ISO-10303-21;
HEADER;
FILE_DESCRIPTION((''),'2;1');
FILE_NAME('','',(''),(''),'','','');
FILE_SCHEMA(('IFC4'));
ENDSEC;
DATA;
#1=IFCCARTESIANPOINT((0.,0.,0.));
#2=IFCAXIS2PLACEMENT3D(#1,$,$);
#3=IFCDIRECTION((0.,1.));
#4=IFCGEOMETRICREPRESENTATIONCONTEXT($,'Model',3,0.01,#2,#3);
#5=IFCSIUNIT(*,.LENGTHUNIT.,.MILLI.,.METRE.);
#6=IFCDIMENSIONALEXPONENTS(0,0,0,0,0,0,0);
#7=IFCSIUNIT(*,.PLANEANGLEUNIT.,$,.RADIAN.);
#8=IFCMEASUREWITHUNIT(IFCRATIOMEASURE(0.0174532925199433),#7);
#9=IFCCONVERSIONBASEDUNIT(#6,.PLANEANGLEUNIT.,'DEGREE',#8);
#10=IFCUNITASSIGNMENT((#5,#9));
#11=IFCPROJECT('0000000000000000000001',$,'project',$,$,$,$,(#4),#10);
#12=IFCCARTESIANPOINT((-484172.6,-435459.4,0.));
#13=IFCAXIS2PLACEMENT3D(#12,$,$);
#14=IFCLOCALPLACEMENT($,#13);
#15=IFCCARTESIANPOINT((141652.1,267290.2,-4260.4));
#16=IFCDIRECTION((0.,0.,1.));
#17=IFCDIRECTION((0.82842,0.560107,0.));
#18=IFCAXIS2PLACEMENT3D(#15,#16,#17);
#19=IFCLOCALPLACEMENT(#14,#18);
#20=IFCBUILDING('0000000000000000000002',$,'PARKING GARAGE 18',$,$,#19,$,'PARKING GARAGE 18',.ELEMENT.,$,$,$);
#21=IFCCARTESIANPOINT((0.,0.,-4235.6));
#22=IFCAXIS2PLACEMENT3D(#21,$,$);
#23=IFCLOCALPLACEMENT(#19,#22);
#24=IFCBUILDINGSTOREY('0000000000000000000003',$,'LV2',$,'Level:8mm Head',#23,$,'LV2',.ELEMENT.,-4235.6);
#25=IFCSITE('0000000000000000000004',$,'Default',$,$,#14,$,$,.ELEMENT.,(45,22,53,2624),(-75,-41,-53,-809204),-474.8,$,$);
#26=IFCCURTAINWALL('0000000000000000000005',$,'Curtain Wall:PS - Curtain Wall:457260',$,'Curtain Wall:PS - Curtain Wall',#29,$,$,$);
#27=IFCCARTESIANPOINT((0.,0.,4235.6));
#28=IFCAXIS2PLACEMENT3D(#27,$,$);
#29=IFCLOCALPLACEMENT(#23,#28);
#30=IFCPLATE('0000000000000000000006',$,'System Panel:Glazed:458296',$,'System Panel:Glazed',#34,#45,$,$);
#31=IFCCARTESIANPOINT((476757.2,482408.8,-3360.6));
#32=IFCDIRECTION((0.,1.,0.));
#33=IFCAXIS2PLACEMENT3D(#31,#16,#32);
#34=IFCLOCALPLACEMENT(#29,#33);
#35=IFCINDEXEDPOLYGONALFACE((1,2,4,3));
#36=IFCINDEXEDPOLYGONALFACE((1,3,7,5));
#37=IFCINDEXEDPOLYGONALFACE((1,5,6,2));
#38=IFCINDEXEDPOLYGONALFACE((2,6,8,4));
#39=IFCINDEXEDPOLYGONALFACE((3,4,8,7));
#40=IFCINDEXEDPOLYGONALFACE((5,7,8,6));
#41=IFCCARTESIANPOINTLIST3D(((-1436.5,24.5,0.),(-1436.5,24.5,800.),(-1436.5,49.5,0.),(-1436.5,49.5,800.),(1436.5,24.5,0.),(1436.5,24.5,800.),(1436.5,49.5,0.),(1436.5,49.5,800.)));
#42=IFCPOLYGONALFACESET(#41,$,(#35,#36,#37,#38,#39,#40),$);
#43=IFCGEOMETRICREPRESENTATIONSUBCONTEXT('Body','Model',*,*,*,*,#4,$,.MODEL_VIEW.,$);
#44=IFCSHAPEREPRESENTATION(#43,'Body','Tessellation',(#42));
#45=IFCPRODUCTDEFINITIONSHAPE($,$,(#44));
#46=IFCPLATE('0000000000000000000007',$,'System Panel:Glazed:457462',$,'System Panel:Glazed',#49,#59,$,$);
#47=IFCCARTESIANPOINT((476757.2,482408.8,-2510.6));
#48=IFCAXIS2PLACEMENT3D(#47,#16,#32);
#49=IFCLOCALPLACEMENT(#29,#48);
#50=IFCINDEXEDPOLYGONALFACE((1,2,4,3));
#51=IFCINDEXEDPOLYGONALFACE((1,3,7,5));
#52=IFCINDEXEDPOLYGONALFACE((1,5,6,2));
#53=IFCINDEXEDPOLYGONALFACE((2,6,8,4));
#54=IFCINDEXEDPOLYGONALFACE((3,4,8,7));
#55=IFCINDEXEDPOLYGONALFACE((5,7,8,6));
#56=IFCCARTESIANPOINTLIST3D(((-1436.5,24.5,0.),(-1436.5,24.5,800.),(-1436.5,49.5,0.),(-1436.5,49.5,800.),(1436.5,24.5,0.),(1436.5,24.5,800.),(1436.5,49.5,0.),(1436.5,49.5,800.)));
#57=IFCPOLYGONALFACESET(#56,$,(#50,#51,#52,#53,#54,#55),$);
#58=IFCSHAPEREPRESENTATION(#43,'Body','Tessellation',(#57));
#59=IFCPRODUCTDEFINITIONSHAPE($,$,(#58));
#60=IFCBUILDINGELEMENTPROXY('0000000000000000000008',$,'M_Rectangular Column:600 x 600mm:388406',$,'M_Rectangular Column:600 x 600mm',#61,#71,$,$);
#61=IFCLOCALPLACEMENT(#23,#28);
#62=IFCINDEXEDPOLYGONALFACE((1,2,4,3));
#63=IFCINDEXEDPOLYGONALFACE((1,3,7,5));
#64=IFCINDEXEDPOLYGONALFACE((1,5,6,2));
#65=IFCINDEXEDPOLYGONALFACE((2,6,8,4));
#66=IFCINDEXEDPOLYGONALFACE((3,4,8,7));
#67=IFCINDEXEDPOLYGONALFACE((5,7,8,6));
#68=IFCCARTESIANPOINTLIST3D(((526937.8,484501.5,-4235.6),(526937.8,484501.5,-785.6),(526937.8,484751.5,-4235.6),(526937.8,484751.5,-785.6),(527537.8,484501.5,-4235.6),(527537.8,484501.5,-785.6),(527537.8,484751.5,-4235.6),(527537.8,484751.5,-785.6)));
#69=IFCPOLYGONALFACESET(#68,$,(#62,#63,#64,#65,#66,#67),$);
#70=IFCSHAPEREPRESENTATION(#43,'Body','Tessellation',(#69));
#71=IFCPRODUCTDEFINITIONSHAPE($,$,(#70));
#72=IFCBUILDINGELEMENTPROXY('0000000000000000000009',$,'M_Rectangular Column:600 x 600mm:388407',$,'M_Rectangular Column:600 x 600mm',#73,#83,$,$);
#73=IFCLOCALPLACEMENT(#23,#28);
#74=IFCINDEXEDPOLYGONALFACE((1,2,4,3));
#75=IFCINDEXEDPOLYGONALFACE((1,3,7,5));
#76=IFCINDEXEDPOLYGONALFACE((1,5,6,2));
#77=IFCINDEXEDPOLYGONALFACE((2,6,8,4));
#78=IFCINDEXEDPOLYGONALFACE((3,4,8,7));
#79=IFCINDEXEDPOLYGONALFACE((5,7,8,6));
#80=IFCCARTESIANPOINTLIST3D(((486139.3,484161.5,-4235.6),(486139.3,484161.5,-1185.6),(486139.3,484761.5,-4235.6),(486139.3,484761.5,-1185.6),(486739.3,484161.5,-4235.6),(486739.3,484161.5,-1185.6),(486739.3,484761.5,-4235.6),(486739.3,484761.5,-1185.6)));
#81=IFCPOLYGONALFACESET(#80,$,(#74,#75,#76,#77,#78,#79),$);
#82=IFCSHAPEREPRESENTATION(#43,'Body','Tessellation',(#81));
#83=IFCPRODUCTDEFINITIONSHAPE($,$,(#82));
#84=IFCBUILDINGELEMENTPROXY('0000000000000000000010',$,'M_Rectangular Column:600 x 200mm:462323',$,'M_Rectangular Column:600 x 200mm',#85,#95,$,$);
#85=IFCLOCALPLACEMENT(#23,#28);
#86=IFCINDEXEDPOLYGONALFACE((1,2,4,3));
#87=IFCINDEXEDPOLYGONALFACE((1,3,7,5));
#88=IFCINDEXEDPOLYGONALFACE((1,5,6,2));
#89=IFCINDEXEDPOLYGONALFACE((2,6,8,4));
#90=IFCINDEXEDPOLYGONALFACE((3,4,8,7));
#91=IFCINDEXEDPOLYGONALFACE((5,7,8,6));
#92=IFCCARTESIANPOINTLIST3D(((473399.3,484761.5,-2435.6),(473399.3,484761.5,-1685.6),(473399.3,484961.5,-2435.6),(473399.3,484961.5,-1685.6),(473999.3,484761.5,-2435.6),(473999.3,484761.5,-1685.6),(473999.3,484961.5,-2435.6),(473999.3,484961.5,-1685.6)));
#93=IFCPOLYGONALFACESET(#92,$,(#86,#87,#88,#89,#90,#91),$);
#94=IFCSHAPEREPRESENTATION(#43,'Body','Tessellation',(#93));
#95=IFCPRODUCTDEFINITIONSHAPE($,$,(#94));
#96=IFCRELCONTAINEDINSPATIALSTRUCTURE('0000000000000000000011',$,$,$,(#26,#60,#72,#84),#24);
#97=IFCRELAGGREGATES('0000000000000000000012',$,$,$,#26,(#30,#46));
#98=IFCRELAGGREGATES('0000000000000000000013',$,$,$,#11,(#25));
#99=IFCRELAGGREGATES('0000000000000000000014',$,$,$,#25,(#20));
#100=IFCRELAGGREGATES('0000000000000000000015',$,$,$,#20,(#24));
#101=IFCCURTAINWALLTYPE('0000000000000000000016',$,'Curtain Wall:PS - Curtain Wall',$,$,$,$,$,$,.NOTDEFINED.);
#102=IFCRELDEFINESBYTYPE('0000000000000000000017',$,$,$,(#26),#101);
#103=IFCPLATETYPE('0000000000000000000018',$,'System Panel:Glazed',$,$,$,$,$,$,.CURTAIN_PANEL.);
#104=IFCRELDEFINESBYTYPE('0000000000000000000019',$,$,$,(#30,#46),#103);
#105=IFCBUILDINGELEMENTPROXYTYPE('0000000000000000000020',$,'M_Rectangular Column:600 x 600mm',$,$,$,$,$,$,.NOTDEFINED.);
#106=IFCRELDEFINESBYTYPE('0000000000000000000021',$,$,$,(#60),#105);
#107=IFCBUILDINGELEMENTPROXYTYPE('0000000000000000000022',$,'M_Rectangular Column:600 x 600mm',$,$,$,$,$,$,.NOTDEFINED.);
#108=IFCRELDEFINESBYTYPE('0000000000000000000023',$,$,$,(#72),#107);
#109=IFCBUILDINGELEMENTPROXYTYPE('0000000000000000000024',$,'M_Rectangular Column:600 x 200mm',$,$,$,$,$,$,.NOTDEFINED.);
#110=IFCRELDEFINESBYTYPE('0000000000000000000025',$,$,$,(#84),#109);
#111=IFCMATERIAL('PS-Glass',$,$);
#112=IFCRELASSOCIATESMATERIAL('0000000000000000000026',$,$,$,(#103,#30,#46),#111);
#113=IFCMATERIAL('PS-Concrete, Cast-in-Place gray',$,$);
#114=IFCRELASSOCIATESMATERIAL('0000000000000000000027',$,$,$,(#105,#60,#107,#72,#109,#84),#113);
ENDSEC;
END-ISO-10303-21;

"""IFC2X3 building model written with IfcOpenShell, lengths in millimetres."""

from ifc_helpers import new_model, entity, si_unit, converted_unit, direction, frame, frame_2d, origin, origin_2d_with_axis, place, context, subcontext, project, spatial, rectangle, extrude, source, transform, mapped, material, type_object, type_shapes, element, aggregate, save


model = new_model("IFC2X3")

# Units and contexts
model_context = context("Model", 3, precision=0.01, world=origin(), true_north=direction((0.0, 1.0)))
body_context = subcontext(model_context, "Body", "Model", "MODEL_VIEW")
ifc_project = project(units=[si_unit("LENGTHUNIT", "METRE", prefix="MILLI"), converted_unit("PLANEANGLEUNIT", "DEGREE", entity("IfcRatioMeasure", 0.0174532925199433), si_unit("PLANEANGLEUNIT", "RADIAN"), dimensions=[0, 0, 0, 0, 0, 0, 0])], contexts=[model_context])

# Site, building, storey
site_placement = place(None, frame((-484172.6, -435459.4, 0.0)))
site = spatial("IfcSite", under=ifc_project, at=site_placement, Name="Default", CompositionType="ELEMENT", RefLatitude=(45, 22, 53, 2624), RefLongitude=(-75, -41, -53, -809204), RefElevation=-474.8)
building_placement = place(site_placement, frame((141652.1, 267290.2, -4260.4), z_axis=(0.0, 0.0, 1.0), x_axis=(0.82842, 0.560107, 0.0)))
building = spatial("IfcBuilding", under=site, at=building_placement, Name="PARKING GARAGE 18", LongName="PARKING GARAGE 18", CompositionType="ELEMENT")
storey_placement = place(building_placement, frame((0.0, 0.0, -4235.6)))
storey = spatial("IfcBuildingStorey", under=building, at=storey_placement, Name="LV2", ObjectType="Level:8mm Head", LongName="LV2", CompositionType="ELEMENT", Elevation=-4235.6)

# Curtain wall, plates
curtain_wall_type = type_object("IfcCurtainWallType", Name="Curtain Wall:PS - Curtain Wall", PredefinedType="NOTDEFINED")
ifc_material_1 = material(Name="PS-Glass")
curtain_wall_1_placement = place(storey_placement, frame((0.0, 0.0, 4235.6)))
curtain_wall_1 = element("IfcCurtainWall", 1, at=curtain_wall_1_placement, inside=storey, type_object=curtain_wall_type, Name="Curtain Wall:PS - Curtain Wall:457260", ObjectType="Curtain Wall:PS - Curtain Wall")
plate_type_1 = type_object("IfcPlateType", Name="System Panel:Glazed", PredefinedType="CURTAIN_PANEL", material=ifc_material_1)
shared_shape_1 = source(origin(), body_context, "Body", "SweptSolid", [
    extrude(rectangle(XDim=25.0, YDim=2873.0, at=origin_2d_with_axis()), frame((0.0, 37.0, 0.0), z_axis=(0.0, 0.0, 1.0), x_axis=(0.0, 1.0, 0.0)), (0.0, 0.0, 1.0), 800.0),
])
type_shapes(plate_type_1, [shared_shape_1])
plate_1_placement = place(curtain_wall_1_placement, frame((476757.2, 482408.8, -3360.6), z_axis=(0.0, 0.0, 1.0), x_axis=(0.0, 1.0, 0.0)))
plate_1 = element("IfcPlate", 2, at=plate_1_placement, type_object=plate_type_1, material=ifc_material_1, Name="System Panel:Glazed:458296", ObjectType="System Panel:Glazed", context=body_context, shape_type="MappedRepresentation", body=[
    mapped(shared_shape_1, transform((0.0, 0.0, 0.0), scale=1.0)),
])
plate_2_placement = place(curtain_wall_1_placement, frame((476757.2, 482408.8, -2510.6), z_axis=(0.0, 0.0, 1.0), x_axis=(0.0, 1.0, 0.0)))
plate_2 = element("IfcPlate", 3, at=plate_2_placement, type_object=plate_type_1, material=ifc_material_1, Name="System Panel:Glazed:457462", ObjectType="System Panel:Glazed", context=body_context, shape_type="MappedRepresentation", body=[
    mapped(shared_shape_1, transform((0.0, 0.0, 0.0), scale=1.0)),
])
aggregate(curtain_wall_1, [plate_1, plate_2])

# Shared definitions
ifc_material_2 = material(Name="PS-Concrete, Cast-in-Place gray")

# Building element proxies
building_element_proxy_type_1 = type_object("IfcBuildingElementProxyType", Name="M_Rectangular Column:600 x 600mm", PredefinedType="NOTDEFINED", material=ifc_material_2)
shared_shape_2 = source(origin(), body_context, "Body", "SweptSolid", [
    extrude(rectangle(XDim=250.0, YDim=600.0, at=origin_2d_with_axis()), frame((527237.8, 484626.5, -4235.6), z_axis=(0.0, 0.0, 1.0), x_axis=(0.0, -1.0, 0.0)), (0.0, 0.0, 1.0), 3450.0),
])
type_shapes(building_element_proxy_type_1, [shared_shape_2])
proxy_1_placement = place(storey_placement, frame((0.0, 0.0, 4235.6)))
element("IfcBuildingElementProxy", 4, at=proxy_1_placement, inside=storey, type_object=building_element_proxy_type_1, material=ifc_material_2, Name="M_Rectangular Column:600 x 600mm:388406", ObjectType="M_Rectangular Column:600 x 600mm", context=body_context, shape_type="MappedRepresentation", body=[
    mapped(shared_shape_2, transform((0.0, 0.0, 0.0), scale=1.0)),
])
building_element_proxy_type_2 = type_object("IfcBuildingElementProxyType", Name="M_Rectangular Column:600 x 600mm", PredefinedType="NOTDEFINED", material=ifc_material_2)
shared_shape_3 = source(origin(), body_context, "Body", "SweptSolid", [
    extrude(rectangle(XDim=600.0, YDim=600.0, at=origin_2d_with_axis()), frame((486439.3, 484461.5, -4235.6), z_axis=(0.0, 0.0, 1.0), x_axis=(0.0, 1.0, 0.0)), (0.0, 0.0, 1.0), 3050.0),
])
type_shapes(building_element_proxy_type_2, [shared_shape_3])
proxy_2_placement = place(storey_placement, frame((0.0, 0.0, 4235.6)))
element("IfcBuildingElementProxy", 5, at=proxy_2_placement, inside=storey, type_object=building_element_proxy_type_2, material=ifc_material_2, Name="M_Rectangular Column:600 x 600mm:388407", ObjectType="M_Rectangular Column:600 x 600mm", context=body_context, shape_type="MappedRepresentation", body=[
    mapped(shared_shape_3, transform((0.0, 0.0, 0.0), scale=1.0)),
])
building_element_proxy_type_3 = type_object("IfcBuildingElementProxyType", Name="M_Rectangular Column:600 x 200mm", PredefinedType="NOTDEFINED", material=ifc_material_2)
shared_shape_4 = source(origin(), body_context, "Body", "SweptSolid", [
    extrude(rectangle(XDim=200.0, YDim=600.0, at=frame_2d((0.0, 0.0), x_axis=(1.0, 0.0))), frame((473699.3, 484861.5, -2435.6), z_axis=(0.0, 0.0, 1.0), x_axis=(0.0, 1.0, 0.0)), (0.0, 0.0, 1.0), 750.0),
])
type_shapes(building_element_proxy_type_3, [shared_shape_4])
proxy_3_placement = place(storey_placement, frame((0.0, 0.0, 4235.6)))
element("IfcBuildingElementProxy", 6, at=proxy_3_placement, inside=storey, type_object=building_element_proxy_type_3, material=ifc_material_2, Name="M_Rectangular Column:600 x 200mm:462323", ObjectType="M_Rectangular Column:600 x 200mm", context=body_context, shape_type="MappedRepresentation", body=[
    mapped(shared_shape_4, transform((0.0, 0.0, 0.0), scale=1.0)),
])

save(model, "model.ifc")
